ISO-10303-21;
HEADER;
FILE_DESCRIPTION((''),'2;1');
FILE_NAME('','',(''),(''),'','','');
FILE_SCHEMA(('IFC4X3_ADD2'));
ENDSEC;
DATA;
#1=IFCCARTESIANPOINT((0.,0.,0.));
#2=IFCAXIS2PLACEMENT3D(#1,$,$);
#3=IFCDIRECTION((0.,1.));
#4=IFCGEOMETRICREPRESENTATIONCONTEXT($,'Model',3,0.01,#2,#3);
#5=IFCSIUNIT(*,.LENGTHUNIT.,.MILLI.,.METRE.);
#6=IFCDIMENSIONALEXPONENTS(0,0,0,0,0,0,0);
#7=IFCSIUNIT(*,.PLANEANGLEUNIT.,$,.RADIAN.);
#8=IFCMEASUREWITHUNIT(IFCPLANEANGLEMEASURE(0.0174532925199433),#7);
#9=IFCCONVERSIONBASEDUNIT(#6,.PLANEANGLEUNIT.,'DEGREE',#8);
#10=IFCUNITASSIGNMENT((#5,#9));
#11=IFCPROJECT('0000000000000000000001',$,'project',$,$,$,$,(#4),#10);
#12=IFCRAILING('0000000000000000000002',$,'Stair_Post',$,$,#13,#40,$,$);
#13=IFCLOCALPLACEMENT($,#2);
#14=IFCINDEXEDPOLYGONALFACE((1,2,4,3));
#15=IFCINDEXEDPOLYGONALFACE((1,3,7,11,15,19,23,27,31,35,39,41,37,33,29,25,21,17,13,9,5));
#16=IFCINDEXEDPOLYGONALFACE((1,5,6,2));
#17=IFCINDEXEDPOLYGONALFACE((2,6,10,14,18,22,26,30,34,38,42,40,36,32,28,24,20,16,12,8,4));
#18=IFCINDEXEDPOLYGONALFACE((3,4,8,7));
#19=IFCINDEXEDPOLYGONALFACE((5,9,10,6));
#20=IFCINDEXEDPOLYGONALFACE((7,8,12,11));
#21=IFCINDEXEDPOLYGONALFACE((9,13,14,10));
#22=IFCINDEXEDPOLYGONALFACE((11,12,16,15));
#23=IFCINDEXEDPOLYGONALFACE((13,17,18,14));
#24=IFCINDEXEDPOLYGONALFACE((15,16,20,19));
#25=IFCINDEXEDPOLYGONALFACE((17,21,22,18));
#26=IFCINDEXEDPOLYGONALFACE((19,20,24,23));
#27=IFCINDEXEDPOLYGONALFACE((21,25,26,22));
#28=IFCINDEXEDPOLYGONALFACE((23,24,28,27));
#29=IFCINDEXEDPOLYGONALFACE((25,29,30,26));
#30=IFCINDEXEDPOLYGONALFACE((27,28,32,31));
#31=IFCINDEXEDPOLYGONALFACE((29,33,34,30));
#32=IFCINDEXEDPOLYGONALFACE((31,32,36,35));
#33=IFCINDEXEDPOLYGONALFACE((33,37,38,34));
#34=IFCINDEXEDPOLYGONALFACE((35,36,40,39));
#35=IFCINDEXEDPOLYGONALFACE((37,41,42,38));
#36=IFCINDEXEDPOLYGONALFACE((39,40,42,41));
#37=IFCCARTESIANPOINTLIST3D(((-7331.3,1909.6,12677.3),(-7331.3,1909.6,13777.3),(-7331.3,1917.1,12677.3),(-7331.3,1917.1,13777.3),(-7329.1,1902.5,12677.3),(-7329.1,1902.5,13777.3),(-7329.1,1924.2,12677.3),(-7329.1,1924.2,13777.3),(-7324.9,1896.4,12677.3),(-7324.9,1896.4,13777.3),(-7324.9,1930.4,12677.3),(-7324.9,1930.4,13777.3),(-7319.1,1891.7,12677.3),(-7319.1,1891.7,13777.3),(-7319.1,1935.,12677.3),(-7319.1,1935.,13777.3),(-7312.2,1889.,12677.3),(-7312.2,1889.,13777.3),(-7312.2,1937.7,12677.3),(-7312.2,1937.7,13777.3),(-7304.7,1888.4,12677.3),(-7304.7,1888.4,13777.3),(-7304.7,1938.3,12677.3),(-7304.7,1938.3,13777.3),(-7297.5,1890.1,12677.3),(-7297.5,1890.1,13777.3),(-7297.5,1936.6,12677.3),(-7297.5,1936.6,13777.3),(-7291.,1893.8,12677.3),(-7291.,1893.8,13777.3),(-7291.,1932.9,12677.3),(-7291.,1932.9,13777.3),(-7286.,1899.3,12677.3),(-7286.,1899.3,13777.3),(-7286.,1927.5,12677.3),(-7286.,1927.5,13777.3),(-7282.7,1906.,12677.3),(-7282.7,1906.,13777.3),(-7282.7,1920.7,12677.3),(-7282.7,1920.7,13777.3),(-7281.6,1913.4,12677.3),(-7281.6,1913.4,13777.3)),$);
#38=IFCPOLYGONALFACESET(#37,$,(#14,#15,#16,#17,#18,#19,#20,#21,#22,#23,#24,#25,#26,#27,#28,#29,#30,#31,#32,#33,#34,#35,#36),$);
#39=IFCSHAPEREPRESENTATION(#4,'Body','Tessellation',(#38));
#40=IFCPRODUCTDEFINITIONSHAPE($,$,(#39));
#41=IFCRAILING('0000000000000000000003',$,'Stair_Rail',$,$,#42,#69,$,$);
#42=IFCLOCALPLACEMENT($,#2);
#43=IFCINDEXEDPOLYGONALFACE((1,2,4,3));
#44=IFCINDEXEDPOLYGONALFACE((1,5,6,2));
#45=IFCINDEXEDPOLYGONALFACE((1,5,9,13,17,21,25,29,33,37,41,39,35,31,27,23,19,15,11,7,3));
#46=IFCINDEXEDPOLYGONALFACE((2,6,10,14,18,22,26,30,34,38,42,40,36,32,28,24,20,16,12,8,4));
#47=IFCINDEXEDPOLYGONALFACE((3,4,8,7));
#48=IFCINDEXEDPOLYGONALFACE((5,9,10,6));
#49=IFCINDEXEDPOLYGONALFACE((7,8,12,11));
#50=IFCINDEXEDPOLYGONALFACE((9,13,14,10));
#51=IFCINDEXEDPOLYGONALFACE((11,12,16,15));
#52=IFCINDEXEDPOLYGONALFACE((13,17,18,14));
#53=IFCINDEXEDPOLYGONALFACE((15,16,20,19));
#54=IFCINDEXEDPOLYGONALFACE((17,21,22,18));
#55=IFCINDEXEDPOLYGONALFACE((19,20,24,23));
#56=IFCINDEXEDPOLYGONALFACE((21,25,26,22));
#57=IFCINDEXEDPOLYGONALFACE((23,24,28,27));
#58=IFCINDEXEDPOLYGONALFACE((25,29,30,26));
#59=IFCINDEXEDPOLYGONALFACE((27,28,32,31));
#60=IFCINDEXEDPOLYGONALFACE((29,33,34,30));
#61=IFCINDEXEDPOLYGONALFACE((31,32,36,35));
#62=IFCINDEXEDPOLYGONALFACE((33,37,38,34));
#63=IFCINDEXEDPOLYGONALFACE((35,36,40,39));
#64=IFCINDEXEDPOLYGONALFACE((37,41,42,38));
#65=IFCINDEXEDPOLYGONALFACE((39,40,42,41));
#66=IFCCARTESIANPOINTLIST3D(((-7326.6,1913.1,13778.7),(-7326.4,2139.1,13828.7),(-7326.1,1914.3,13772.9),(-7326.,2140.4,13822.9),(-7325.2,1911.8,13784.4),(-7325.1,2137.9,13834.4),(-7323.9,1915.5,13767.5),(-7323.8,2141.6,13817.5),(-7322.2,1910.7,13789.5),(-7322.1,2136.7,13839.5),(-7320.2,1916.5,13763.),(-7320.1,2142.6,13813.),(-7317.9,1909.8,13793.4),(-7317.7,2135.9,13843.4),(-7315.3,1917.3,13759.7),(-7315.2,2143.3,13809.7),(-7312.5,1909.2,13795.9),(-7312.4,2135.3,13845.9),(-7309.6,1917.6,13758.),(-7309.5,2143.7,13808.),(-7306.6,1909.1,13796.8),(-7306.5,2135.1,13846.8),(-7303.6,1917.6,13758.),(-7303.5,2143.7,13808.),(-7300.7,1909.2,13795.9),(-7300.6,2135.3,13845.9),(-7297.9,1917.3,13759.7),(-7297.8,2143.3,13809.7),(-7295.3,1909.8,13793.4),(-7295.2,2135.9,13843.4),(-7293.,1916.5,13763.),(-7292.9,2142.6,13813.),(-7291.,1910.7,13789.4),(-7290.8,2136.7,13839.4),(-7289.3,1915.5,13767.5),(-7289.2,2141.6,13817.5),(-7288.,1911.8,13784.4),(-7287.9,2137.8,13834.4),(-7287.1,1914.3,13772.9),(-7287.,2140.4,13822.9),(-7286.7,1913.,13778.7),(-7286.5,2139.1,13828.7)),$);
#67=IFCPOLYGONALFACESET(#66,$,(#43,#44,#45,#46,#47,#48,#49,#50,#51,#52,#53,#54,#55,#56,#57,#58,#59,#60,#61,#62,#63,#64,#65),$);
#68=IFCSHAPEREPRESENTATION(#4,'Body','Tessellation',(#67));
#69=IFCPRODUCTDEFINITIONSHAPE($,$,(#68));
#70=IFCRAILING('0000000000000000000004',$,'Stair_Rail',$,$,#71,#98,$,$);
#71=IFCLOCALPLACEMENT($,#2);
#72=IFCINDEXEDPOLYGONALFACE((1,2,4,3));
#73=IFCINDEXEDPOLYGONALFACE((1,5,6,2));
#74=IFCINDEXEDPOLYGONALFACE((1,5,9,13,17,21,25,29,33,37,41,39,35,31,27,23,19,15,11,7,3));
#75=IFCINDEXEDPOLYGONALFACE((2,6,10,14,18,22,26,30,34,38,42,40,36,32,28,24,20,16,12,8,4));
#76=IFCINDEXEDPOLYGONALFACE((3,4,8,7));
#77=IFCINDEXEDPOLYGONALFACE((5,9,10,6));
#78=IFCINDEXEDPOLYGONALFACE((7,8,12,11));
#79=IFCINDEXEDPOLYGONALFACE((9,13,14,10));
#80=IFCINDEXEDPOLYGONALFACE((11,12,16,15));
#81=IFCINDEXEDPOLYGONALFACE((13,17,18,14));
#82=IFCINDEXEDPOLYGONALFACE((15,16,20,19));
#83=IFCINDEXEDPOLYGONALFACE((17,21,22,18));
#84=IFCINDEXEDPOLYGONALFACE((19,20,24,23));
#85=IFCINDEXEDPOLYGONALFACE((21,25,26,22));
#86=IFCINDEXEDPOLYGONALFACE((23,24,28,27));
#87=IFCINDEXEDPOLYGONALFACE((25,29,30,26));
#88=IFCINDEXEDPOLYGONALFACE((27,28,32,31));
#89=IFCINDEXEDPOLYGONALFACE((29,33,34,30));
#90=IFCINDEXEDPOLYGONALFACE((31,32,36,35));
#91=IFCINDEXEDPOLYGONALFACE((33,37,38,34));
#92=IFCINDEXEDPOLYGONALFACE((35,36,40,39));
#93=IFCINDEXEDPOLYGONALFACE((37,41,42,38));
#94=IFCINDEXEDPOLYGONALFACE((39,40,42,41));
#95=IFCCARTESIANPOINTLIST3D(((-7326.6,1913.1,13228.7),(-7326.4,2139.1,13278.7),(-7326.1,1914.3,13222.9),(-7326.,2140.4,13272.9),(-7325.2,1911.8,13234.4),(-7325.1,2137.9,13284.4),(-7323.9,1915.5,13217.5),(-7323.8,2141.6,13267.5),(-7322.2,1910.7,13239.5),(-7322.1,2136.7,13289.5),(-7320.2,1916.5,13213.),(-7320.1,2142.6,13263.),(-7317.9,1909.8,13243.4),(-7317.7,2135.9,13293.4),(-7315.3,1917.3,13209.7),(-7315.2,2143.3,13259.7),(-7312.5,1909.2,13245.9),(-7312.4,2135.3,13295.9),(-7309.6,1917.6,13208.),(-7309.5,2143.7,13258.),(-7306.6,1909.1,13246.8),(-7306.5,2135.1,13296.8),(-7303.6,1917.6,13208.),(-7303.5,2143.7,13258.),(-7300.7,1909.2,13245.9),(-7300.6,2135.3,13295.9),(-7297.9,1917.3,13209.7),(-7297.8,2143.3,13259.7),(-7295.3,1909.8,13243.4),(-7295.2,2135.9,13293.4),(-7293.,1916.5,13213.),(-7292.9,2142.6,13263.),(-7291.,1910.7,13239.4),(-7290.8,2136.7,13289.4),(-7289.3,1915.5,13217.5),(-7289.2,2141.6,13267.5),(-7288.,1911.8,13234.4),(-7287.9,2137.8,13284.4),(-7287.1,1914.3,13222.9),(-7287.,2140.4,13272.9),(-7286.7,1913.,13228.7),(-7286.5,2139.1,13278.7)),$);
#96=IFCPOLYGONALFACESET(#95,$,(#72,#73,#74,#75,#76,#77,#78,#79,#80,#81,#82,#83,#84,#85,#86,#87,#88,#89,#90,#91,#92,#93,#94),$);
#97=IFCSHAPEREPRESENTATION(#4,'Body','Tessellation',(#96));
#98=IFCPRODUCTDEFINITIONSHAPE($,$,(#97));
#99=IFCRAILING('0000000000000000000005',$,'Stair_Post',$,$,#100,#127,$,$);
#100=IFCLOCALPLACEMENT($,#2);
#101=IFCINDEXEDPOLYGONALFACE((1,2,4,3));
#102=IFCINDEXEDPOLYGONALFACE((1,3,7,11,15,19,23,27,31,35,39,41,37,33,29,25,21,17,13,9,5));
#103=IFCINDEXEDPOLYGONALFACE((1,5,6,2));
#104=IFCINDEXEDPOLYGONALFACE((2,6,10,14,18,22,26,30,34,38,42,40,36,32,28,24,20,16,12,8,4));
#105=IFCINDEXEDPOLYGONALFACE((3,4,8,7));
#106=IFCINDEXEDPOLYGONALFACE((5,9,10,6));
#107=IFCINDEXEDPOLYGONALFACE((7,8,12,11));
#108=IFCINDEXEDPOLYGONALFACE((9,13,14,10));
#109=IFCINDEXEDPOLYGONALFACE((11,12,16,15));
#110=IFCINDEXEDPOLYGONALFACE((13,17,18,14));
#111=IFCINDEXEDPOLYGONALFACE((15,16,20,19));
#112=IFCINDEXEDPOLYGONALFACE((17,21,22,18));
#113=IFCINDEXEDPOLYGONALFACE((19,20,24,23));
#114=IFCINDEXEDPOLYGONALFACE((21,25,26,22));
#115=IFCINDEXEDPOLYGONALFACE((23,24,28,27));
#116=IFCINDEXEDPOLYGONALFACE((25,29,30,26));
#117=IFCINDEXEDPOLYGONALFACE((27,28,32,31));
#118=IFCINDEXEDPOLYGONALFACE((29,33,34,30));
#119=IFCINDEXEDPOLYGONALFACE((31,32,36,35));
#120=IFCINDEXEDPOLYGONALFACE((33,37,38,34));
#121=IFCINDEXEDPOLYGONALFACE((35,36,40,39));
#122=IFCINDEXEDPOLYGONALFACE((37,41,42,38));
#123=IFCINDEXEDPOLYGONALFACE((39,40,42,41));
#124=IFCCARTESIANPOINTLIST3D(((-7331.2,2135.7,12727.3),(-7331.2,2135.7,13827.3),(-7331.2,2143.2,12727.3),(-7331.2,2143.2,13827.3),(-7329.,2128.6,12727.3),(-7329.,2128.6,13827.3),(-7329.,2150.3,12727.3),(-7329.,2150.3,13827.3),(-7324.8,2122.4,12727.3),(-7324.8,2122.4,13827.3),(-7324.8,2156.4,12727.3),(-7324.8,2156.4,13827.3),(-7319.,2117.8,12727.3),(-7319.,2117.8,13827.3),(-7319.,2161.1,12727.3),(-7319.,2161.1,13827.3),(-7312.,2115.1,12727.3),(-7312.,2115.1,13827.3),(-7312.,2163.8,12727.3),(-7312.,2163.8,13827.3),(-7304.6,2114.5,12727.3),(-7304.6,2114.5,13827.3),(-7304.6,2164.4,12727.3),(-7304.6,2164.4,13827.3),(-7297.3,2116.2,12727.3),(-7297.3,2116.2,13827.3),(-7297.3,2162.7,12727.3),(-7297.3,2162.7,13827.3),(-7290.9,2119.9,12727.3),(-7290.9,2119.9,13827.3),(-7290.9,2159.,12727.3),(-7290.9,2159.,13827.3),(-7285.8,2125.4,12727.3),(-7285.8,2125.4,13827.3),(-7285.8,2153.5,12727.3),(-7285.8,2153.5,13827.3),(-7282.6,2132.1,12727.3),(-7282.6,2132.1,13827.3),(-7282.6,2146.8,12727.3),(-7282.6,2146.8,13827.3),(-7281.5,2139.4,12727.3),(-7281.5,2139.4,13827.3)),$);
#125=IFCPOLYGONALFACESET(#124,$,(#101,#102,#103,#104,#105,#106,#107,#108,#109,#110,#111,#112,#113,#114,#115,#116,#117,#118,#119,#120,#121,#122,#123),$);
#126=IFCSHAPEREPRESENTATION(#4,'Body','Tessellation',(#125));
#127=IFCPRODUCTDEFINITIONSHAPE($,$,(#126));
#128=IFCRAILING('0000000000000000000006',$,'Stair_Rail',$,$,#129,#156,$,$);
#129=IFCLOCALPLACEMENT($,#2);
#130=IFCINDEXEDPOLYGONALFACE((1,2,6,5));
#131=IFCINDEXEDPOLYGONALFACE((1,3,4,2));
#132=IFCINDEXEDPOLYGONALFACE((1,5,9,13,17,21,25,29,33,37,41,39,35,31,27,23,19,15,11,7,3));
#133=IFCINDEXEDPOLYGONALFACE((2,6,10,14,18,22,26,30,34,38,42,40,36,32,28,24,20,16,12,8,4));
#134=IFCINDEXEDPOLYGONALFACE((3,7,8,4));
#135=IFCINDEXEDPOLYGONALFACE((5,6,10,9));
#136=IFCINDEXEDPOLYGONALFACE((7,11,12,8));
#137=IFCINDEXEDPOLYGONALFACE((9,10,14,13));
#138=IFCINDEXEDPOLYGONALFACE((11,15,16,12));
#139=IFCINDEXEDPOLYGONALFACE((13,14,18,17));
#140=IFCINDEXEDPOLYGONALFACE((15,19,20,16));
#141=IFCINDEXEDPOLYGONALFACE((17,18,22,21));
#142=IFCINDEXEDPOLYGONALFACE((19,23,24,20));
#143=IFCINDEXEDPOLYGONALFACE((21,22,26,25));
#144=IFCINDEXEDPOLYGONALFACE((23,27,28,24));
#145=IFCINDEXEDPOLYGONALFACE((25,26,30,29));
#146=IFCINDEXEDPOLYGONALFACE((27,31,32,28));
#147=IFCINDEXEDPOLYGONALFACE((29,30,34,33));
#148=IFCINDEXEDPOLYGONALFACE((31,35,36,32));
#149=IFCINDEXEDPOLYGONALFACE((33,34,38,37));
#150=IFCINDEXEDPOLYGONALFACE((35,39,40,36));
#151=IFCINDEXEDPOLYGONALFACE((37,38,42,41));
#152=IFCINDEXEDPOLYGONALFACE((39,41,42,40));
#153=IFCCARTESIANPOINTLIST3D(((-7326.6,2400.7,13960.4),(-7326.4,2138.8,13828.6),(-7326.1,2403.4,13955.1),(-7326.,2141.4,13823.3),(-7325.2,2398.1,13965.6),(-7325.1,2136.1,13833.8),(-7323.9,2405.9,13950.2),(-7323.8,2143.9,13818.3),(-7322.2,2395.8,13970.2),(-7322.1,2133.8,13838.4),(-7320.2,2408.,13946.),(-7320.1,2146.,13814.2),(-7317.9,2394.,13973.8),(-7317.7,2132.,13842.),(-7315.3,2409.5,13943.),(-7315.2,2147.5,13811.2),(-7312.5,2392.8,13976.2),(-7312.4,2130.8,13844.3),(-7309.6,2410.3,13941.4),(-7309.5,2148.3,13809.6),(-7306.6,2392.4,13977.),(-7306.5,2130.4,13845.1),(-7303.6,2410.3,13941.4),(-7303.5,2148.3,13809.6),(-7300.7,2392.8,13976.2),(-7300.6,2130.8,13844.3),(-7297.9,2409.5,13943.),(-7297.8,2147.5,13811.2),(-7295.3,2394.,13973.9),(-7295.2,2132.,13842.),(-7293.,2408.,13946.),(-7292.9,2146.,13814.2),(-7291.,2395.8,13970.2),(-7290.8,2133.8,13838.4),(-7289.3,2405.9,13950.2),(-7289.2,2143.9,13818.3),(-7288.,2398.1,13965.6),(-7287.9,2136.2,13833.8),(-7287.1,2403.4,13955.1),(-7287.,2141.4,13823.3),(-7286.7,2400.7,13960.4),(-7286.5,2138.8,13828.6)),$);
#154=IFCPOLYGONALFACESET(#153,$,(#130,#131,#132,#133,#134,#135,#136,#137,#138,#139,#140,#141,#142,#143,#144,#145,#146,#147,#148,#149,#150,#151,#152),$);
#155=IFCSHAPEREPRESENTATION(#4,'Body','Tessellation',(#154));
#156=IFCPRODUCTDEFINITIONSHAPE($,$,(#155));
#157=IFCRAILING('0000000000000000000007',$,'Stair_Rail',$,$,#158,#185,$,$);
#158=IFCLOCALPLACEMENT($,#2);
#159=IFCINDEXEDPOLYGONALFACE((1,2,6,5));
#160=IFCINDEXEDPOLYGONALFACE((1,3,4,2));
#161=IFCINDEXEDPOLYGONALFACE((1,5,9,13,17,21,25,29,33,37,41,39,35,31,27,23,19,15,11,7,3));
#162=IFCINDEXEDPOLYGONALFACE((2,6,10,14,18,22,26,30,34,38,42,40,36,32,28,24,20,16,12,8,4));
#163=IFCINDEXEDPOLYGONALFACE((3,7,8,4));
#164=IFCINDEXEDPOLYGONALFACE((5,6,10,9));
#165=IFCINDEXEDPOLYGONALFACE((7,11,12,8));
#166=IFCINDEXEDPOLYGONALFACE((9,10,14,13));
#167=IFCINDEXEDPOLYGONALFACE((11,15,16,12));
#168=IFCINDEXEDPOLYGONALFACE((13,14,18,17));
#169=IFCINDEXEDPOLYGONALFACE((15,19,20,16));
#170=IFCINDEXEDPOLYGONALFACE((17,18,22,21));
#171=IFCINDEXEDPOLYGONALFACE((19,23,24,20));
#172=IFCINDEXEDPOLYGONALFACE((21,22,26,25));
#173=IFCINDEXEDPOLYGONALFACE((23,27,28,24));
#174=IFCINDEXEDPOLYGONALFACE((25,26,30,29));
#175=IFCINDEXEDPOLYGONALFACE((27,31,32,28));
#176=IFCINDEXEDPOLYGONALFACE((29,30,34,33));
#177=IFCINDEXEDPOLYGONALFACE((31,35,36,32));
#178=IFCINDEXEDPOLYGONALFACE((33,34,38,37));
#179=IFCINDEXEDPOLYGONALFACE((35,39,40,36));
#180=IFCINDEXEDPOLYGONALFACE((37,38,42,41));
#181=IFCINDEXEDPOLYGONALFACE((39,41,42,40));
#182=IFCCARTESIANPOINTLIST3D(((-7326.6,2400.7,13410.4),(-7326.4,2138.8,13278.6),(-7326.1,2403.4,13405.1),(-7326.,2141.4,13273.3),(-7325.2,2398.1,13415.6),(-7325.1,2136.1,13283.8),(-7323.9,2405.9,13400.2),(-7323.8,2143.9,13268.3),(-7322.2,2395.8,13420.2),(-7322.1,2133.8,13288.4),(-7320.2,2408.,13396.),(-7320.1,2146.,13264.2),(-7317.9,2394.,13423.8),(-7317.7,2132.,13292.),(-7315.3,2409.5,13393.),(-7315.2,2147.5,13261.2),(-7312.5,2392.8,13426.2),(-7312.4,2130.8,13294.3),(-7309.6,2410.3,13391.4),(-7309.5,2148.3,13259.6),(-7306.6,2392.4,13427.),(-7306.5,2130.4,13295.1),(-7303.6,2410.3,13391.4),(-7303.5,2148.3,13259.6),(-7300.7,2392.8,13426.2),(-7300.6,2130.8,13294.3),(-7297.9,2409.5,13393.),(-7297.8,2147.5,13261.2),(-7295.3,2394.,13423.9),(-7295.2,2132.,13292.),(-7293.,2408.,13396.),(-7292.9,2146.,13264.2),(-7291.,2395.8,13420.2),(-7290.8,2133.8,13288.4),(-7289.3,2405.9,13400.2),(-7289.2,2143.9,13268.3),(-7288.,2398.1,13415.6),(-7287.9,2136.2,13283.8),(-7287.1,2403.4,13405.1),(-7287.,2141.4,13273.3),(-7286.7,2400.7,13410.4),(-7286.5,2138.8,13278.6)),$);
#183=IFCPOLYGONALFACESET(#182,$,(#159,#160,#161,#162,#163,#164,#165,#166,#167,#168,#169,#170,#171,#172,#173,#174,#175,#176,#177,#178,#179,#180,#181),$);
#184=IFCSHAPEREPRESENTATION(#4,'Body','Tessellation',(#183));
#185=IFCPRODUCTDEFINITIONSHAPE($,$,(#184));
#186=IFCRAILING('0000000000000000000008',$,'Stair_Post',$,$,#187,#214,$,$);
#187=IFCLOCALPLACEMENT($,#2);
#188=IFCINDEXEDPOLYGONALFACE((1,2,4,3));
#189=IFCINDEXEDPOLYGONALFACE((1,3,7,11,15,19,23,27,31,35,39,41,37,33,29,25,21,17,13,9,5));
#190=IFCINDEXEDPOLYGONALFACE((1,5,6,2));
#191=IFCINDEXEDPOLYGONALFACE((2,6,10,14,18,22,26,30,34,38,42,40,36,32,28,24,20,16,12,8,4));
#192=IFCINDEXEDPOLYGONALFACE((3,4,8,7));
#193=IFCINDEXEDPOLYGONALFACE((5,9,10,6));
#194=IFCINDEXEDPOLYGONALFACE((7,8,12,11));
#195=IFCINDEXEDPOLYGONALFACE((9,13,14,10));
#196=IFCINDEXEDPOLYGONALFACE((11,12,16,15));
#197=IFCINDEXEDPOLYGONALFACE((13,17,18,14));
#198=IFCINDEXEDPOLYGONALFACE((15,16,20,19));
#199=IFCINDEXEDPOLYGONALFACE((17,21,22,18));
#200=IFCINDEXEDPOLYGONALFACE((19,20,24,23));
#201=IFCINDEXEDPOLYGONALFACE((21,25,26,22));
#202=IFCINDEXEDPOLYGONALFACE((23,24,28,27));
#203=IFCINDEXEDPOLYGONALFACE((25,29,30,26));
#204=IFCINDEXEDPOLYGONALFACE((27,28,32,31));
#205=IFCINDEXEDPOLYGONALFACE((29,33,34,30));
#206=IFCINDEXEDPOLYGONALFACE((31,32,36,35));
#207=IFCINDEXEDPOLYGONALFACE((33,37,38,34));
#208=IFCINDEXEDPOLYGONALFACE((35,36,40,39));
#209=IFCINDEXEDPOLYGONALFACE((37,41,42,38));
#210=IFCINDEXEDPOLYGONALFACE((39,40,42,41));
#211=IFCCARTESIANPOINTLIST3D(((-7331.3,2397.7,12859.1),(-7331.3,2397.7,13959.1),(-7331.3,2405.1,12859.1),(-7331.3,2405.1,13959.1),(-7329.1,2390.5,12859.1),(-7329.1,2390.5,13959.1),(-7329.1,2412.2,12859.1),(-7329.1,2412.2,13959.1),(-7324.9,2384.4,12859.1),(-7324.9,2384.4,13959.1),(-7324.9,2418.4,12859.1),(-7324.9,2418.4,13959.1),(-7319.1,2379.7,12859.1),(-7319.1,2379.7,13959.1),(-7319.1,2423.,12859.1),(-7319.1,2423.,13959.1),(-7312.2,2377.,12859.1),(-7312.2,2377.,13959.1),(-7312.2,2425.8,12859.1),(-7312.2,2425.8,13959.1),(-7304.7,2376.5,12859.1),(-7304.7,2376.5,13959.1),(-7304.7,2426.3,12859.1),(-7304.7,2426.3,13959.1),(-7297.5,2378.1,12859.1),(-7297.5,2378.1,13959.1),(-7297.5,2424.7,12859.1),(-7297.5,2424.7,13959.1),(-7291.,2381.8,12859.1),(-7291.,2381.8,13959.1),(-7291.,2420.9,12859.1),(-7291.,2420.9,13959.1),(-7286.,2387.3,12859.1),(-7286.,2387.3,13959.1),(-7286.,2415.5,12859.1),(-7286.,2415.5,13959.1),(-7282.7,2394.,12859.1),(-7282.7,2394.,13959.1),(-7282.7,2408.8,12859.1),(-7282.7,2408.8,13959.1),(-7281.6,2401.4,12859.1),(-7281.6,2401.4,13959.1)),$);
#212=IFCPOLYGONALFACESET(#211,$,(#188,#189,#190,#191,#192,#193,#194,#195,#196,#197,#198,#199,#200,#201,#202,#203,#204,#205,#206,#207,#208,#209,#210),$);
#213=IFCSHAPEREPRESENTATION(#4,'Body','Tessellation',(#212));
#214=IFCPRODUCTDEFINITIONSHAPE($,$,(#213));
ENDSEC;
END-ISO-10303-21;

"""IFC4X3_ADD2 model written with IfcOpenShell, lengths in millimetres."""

from ifc_helpers import new_model, entity, si_unit, converted_unit, direction, frame, origin, context, project, circle, extrude, element, save


model = new_model("IFC4X3_ADD2")

# Units and contexts
model_context = context("Model", 3, precision=0.01, world=origin(), true_north=direction((0.0, 1.0)))
ifc_project = project(units=[si_unit("LENGTHUNIT", "METRE", prefix="MILLI"), converted_unit("PLANEANGLEUNIT", "DEGREE", entity("IfcPlaneAngleMeasure", 0.0174532925199433), si_unit("PLANEANGLEUNIT", "RADIAN"), dimensions=[0, 0, 0, 0, 0, 0, 0])], contexts=[model_context])

# Railings
element("IfcRailing", 1, Name="Stair_Post", context=model_context, shape_type="SweptSolid", body=[
    extrude(circle(Radius=25.0), frame((-7306.6, 1913.4, 12677.3)), (0.0, 0.0, 1.0), 1100.0),
])
element("IfcRailing", 2, Name="Stair_Rail", context=model_context, shape_type="SweptSolid", body=[
    entity("IfcSweptDiskSolid", entity("IfcPolyline", [entity("IfcCartesianPoint", [-7306.6, 1913.4, 13777.3]), entity("IfcCartesianPoint", [-7306.5, 2139.4, 13827.3])]), 20.0),
])
element("IfcRailing", 3, Name="Stair_Rail", context=model_context, shape_type="SweptSolid", body=[
    entity("IfcSweptDiskSolid", entity("IfcPolyline", [entity("IfcCartesianPoint", [-7306.6, 1913.4, 13227.3]), entity("IfcCartesianPoint", [-7306.5, 2139.4, 13277.3])]), 20.0),
])
element("IfcRailing", 4, Name="Stair_Post", context=model_context, shape_type="SweptSolid", body=[
    extrude(circle(Radius=25.0), frame((-7306.5, 2139.4, 12727.3)), (0.0, 0.0, 1.0), 1100.0),
])
element("IfcRailing", 5, Name="Stair_Rail", context=model_context, shape_type="SweptSolid", body=[
    entity("IfcSweptDiskSolid", entity("IfcPolyline", [entity("IfcCartesianPoint", [-7306.5, 2139.4, 13827.3]), entity("IfcCartesianPoint", [-7306.6, 2401.4, 13959.1])]), 20.0),
])
element("IfcRailing", 6, Name="Stair_Rail", context=model_context, shape_type="SweptSolid", body=[
    entity("IfcSweptDiskSolid", entity("IfcPolyline", [entity("IfcCartesianPoint", [-7306.5, 2139.4, 13277.3]), entity("IfcCartesianPoint", [-7306.6, 2401.4, 13409.1])]), 20.0),
])
element("IfcRailing", 7, Name="Stair_Post", context=model_context, shape_type="SweptSolid", body=[
    extrude(circle(Radius=25.0), frame((-7306.6, 2401.4, 12859.1)), (0.0, 0.0, 1.0), 1100.0),
])

save(model, "model.ifc")
